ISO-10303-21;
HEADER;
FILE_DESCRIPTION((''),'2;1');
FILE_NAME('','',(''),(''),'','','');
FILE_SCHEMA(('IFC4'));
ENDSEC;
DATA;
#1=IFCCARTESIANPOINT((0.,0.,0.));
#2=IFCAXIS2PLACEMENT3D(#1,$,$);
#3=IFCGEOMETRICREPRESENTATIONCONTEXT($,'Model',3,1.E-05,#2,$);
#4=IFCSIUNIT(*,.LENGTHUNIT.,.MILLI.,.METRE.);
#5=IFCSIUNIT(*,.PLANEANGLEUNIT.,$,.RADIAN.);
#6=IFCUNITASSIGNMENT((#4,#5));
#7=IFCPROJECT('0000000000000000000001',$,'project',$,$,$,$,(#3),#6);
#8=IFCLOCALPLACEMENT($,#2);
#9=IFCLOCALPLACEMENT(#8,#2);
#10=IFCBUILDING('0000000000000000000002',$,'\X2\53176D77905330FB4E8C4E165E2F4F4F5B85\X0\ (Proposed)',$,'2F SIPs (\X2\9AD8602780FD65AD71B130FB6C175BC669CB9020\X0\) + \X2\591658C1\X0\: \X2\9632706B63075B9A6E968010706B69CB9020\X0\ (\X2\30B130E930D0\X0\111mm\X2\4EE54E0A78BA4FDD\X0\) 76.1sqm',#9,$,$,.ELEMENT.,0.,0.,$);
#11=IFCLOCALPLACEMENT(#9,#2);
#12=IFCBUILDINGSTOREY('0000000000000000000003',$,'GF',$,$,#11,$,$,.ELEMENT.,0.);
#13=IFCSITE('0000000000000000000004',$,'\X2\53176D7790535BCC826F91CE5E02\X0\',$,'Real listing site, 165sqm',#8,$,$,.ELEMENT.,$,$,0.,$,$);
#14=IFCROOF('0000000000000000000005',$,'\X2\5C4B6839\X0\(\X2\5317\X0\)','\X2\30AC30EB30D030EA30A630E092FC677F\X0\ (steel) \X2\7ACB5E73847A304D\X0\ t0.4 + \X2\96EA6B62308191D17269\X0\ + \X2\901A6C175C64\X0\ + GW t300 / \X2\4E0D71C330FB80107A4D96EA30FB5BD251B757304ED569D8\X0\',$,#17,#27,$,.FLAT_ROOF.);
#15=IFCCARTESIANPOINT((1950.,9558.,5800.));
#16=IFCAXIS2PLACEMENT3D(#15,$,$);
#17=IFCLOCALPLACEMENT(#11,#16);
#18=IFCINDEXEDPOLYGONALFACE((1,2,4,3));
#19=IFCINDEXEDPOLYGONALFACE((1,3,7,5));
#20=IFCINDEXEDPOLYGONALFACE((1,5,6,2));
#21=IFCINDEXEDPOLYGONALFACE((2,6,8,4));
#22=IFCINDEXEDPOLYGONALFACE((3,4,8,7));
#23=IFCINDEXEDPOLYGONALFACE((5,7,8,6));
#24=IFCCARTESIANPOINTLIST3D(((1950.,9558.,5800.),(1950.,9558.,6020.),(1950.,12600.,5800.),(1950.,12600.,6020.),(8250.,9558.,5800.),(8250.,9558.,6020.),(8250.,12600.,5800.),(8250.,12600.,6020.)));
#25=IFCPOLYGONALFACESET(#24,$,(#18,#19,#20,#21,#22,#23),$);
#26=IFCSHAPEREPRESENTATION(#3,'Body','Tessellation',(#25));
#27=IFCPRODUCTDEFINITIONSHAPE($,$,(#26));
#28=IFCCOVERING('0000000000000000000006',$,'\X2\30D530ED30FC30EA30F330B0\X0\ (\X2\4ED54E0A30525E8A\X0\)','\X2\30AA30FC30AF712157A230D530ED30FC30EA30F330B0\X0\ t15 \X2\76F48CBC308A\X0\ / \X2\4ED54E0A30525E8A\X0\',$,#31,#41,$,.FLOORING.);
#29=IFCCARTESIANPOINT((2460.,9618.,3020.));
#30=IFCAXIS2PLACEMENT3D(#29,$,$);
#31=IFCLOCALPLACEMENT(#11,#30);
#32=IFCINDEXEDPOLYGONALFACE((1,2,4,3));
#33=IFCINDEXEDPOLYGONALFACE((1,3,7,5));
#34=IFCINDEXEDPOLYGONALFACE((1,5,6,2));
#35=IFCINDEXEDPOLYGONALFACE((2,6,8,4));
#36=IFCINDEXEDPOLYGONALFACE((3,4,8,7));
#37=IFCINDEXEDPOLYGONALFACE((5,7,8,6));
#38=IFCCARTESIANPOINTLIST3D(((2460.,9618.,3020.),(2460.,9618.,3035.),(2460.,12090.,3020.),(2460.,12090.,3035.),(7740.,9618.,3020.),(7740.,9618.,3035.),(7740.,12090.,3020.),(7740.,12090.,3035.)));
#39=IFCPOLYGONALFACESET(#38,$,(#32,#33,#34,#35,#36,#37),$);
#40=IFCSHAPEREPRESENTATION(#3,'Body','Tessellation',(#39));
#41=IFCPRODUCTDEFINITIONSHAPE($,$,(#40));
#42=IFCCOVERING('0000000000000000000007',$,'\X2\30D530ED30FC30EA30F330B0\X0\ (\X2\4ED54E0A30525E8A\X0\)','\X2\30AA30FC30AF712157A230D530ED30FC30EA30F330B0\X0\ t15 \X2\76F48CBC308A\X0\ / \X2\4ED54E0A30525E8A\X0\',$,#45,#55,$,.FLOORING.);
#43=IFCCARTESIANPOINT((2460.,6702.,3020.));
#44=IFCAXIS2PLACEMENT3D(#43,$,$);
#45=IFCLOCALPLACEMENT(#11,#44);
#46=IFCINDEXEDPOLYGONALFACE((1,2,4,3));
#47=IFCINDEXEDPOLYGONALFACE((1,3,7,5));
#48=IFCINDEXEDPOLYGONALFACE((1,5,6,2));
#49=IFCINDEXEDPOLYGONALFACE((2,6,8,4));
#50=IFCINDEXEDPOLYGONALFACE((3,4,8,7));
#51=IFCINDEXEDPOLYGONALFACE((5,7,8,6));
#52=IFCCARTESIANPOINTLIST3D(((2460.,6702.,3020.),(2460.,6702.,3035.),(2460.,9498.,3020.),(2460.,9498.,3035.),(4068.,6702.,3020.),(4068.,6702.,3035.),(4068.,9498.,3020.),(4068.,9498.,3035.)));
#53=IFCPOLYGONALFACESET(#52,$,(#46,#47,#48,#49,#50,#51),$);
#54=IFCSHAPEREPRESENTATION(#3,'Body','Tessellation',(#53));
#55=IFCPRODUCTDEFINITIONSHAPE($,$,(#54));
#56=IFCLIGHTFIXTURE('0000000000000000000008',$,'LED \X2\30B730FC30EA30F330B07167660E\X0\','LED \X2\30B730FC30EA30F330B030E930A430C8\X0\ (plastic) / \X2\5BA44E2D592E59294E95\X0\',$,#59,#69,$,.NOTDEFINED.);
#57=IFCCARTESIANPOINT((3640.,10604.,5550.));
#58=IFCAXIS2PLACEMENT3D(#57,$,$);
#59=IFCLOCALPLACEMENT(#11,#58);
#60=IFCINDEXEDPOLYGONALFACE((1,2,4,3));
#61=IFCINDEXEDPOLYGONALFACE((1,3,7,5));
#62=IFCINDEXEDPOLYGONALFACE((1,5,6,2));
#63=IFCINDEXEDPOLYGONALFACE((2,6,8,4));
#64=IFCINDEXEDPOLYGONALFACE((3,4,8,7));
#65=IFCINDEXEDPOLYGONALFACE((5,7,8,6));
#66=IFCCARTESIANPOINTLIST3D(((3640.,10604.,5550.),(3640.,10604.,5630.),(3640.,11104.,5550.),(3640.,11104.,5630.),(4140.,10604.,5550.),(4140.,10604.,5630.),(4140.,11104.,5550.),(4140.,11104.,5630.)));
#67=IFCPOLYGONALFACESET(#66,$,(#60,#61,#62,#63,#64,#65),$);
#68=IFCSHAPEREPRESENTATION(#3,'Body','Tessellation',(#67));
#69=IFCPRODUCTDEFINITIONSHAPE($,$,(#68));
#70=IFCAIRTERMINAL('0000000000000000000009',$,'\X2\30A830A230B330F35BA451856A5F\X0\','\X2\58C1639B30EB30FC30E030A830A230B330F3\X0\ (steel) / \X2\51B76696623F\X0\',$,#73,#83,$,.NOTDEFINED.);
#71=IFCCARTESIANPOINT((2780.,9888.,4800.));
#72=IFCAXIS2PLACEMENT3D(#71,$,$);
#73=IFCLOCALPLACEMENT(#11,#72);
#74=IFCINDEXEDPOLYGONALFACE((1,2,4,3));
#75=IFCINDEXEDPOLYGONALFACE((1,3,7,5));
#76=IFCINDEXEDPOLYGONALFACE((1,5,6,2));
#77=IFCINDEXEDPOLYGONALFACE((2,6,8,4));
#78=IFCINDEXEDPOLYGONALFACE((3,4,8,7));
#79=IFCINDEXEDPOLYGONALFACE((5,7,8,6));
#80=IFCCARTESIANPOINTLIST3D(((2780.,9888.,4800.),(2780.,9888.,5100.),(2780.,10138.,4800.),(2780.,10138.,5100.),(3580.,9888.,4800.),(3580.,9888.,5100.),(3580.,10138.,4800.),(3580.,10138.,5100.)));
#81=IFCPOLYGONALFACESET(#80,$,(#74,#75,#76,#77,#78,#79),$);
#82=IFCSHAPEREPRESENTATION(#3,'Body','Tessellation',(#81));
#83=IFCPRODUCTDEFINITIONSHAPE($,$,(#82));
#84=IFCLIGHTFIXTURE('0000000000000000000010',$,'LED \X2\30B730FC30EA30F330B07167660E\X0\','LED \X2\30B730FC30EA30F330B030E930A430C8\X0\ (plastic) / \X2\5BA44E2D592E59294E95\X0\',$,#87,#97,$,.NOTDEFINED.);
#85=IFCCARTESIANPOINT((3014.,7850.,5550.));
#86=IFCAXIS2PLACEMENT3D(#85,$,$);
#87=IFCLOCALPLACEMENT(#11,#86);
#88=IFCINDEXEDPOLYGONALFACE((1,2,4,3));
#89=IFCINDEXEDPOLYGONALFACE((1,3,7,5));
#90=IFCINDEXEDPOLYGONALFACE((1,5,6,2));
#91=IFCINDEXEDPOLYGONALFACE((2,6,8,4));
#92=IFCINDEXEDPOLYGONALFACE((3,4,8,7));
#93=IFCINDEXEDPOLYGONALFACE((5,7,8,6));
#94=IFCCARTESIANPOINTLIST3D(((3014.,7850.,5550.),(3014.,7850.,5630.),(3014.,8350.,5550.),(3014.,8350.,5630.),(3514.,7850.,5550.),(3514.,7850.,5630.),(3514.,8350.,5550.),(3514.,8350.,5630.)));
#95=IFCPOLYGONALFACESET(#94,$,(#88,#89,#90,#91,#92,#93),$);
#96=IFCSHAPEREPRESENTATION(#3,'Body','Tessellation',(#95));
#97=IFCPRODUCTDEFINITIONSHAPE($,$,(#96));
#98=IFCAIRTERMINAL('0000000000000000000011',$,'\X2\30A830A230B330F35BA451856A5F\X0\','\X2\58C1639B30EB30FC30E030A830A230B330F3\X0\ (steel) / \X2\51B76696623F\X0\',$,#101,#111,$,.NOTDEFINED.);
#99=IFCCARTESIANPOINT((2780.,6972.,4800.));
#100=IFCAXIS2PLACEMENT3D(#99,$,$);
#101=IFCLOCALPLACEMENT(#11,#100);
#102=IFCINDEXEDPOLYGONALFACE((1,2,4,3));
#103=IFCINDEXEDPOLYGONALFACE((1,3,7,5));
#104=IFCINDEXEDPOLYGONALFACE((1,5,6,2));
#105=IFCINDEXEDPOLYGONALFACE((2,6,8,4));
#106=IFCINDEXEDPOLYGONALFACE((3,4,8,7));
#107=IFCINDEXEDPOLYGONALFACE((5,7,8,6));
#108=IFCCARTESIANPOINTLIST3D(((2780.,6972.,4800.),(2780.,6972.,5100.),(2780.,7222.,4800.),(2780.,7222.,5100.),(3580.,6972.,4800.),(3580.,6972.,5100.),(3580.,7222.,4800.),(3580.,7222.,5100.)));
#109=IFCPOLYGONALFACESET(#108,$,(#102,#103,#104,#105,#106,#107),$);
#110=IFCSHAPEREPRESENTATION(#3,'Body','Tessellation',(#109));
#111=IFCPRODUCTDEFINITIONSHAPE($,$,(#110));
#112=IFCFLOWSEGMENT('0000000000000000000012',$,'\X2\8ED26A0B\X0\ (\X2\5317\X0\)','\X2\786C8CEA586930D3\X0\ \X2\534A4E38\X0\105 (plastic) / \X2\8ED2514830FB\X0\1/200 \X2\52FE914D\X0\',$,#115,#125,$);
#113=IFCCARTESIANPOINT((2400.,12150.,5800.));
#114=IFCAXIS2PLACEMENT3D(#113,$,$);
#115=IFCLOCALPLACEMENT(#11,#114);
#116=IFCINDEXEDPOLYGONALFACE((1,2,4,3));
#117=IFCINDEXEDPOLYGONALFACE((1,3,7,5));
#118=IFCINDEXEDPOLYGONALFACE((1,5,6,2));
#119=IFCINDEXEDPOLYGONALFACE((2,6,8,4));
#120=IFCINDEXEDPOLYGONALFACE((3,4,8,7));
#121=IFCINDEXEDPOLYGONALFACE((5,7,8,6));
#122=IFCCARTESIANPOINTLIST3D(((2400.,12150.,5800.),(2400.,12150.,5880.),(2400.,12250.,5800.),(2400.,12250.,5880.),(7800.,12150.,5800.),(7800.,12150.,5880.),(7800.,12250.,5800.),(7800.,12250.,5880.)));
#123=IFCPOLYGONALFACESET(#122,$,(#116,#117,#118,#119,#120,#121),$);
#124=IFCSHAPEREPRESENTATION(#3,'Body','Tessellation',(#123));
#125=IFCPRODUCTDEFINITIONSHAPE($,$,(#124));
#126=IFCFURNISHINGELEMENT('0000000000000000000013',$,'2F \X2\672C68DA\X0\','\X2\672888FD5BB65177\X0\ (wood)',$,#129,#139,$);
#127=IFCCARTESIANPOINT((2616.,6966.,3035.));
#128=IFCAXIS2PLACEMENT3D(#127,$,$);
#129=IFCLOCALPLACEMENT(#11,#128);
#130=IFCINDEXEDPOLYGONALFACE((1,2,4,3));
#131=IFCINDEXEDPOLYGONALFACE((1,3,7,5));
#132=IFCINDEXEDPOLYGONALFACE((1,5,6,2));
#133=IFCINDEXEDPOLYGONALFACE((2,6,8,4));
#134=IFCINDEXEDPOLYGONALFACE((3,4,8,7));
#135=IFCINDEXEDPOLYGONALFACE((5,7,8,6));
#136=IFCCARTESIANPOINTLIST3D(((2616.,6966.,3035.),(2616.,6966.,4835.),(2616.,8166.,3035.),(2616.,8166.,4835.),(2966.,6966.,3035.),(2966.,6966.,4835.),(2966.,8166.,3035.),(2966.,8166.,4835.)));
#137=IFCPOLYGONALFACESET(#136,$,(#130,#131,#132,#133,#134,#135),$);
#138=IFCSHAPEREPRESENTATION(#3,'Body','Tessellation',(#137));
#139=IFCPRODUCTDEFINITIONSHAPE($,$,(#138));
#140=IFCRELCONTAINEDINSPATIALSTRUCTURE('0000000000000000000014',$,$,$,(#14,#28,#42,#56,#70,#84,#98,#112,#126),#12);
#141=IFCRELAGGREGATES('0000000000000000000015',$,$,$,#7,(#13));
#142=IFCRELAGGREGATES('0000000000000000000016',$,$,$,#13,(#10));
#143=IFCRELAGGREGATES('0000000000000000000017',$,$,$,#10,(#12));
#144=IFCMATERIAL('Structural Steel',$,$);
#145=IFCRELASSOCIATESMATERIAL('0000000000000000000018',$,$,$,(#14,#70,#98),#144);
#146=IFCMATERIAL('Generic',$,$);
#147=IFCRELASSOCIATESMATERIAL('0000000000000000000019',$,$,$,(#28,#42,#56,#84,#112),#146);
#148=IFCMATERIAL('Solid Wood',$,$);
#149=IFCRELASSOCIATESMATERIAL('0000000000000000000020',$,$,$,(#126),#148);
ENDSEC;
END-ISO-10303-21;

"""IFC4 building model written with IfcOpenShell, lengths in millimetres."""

from ifc_helpers import new_model, si_unit, frame, frame_2d, origin, place, context, project, spatial, rectangle, extrude, material, element, save


model = new_model("IFC4")

# Units and contexts
model_context = context("Model", 3, precision=1e-05, world=origin())
ifc_project = project(units=[si_unit("LENGTHUNIT", "METRE", prefix="MILLI"), si_unit("PLANEANGLEUNIT", "RADIAN")], contexts=[model_context])

# Site, building, storey
site_placement = place(None, origin())
site = spatial("IfcSite", under=ifc_project, at=site_placement, Name="北海道富良野市", ObjectType="Real listing site, 165sqm", CompositionType="ELEMENT", RefElevation=0.0)
building_placement = place(site_placement, origin())
building = spatial("IfcBuilding", under=site, at=building_placement, Name="北海道・二世帯住宅 (Proposed)", ObjectType="2F SIPs (高性能断熱・気密構造) + 外壁: 防火指定準耐火構造 (ケラバ111mm以上確保) 76.1sqm", CompositionType="ELEMENT", ElevationOfRefHeight=0.0, ElevationOfTerrain=0.0)
storey_placement = place(building_placement, origin())
storey = spatial("IfcBuildingStorey", under=building, at=storey_placement, Name="GF", CompositionType="ELEMENT", Elevation=0.0)

# Shared definitions
ifc_material_1 = material(Name="Solid Wood")

# Roof
ifc_material_2 = material(Name="Structural Steel")
for number, where, name in (
    (1, (1950.0, 9558.0, 5800.0), "屋根(北)"),
):
    element("IfcRoof", number, at=place(storey_placement, frame(where)), inside=storey, material=ifc_material_2, Name=name, Description="ガルバリウム鋼板 (steel) 立平葺き t0.4 + 雪止め金物 + 通気層 + GW t300 / 不燃・耐積雪・寒冷地仕様", PredefinedType="FLAT_ROOF", context=model_context, shape_type="SweptSolid", body=[
        extrude(rectangle(XDim=6300.0, YDim=3042.0, at=frame_2d((3150.0, 1521.0))), frame((1950.0, 9558.0, 5800.0)), (0.0, 0.0, 1.0), 220.0),
    ])

# Coverings
ifc_material_3 = material(Name="Generic")
covering_1_placement = place(storey_placement, frame((2460.0, 9618.0, 3020.0)))
element("IfcCovering", 2, at=covering_1_placement, inside=storey, material=ifc_material_3, Name="フローリング (仕上げ床)", Description="オーク無垢フローリング t15 直貼り / 仕上げ床", PredefinedType="FLOORING", context=model_context, shape_type="SweptSolid", body=[
    extrude(rectangle(XDim=5280.0, YDim=2472.0, at=frame_2d((2640.0, 1236.0))), frame((2460.0, 9618.0, 3020.0)), (0.0, 0.0, 1.0), 15.0),
])
covering_2_placement = place(storey_placement, frame((2460.0, 6702.0, 3020.0)))
element("IfcCovering", 3, at=covering_2_placement, inside=storey, material=ifc_material_3, Name="フローリング (仕上げ床)", Description="オーク無垢フローリング t15 直貼り / 仕上げ床", PredefinedType="FLOORING", context=model_context, shape_type="SweptSolid", body=[
    extrude(rectangle(XDim=1608.0, YDim=2796.0, at=frame_2d((804.0, 1398.0))), frame((2460.0, 6702.0, 3020.0)), (0.0, 0.0, 1.0), 15.0),
])

# Light fixture
light_fixture_1_placement = place(storey_placement, frame((3640.0, 10604.0, 5550.0)))
element("IfcLightFixture", 4, at=light_fixture_1_placement, inside=storey, material=ifc_material_3, Name="LED シーリング照明", Description="LED シーリングライト (plastic) / 室中央天井", PredefinedType="NOTDEFINED", context=model_context, shape_type="SweptSolid", body=[
    extrude(rectangle(XDim=500.0, YDim=500.0, at=frame_2d((250.0, 250.0))), frame((3640.0, 10604.0, 5550.0)), (0.0, 0.0, 1.0), 80.0),
])

# Air terminal
air_terminal_1_placement = place(storey_placement, frame((2780.0, 9888.0, 4800.0)))
element("IfcAirTerminal", 5, at=air_terminal_1_placement, inside=storey, material=ifc_material_2, Name="エアコン室内機", Description="壁掛ルームエアコン (steel) / 冷暖房", PredefinedType="NOTDEFINED", context=model_context, shape_type="SweptSolid", body=[
    extrude(rectangle(XDim=800.0, YDim=250.0, at=frame_2d((400.0, 125.0))), frame((2780.0, 9888.0, 4800.0)), (0.0, 0.0, 1.0), 300.0),
])

# Light fixture
light_fixture_2_placement = place(storey_placement, frame((3014.0, 7850.0, 5550.0)))
element("IfcLightFixture", 6, at=light_fixture_2_placement, inside=storey, material=ifc_material_3, Name="LED シーリング照明", Description="LED シーリングライト (plastic) / 室中央天井", PredefinedType="NOTDEFINED", context=model_context, shape_type="SweptSolid", body=[
    extrude(rectangle(XDim=500.0, YDim=500.0, at=frame_2d((250.0, 250.0))), frame((3014.0, 7850.0, 5550.0)), (0.0, 0.0, 1.0), 80.0),
])

# Air terminal
air_terminal_2_placement = place(storey_placement, frame((2780.0, 6972.0, 4800.0)))
element("IfcAirTerminal", 7, at=air_terminal_2_placement, inside=storey, material=ifc_material_2, Name="エアコン室内機", Description="壁掛ルームエアコン (steel) / 冷暖房", PredefinedType="NOTDEFINED", context=model_context, shape_type="SweptSolid", body=[
    extrude(rectangle(XDim=800.0, YDim=250.0, at=frame_2d((400.0, 125.0))), frame((2780.0, 6972.0, 4800.0)), (0.0, 0.0, 1.0), 300.0),
])

# Flow segment
flow_segment_placement = place(storey_placement, frame((2400.0, 12150.0, 5800.0)))
element("IfcFlowSegment", 8, at=flow_segment_placement, inside=storey, material=ifc_material_3, Name="軒樋 (北)", Description="硬質塩ビ 半丸105 (plastic) / 軒先・1/200 勾配", context=model_context, shape_type="SweptSolid", body=[
    extrude(rectangle(XDim=5400.0, YDim=100.0, at=frame_2d((2700.0, 50.0))), frame((2400.0, 12150.0, 5800.0)), (0.0, 0.0, 1.0), 80.0),
])

# Furnishing element
furnishing_placement = place(storey_placement, frame((2616.0, 6966.0, 3035.0)))
element("IfcFurnishingElement", 9, at=furnishing_placement, inside=storey, material=ifc_material_1, Name="2F 本棚", Description="木製家具 (wood)", context=model_context, shape_type="SweptSolid", body=[
    extrude(rectangle(XDim=350.0, YDim=1200.0, at=frame_2d((175.0, 600.0))), frame((2616.0, 6966.0, 3035.0)), (0.0, 0.0, 1.0), 1800.0),
])

save(model, "model.ifc")
